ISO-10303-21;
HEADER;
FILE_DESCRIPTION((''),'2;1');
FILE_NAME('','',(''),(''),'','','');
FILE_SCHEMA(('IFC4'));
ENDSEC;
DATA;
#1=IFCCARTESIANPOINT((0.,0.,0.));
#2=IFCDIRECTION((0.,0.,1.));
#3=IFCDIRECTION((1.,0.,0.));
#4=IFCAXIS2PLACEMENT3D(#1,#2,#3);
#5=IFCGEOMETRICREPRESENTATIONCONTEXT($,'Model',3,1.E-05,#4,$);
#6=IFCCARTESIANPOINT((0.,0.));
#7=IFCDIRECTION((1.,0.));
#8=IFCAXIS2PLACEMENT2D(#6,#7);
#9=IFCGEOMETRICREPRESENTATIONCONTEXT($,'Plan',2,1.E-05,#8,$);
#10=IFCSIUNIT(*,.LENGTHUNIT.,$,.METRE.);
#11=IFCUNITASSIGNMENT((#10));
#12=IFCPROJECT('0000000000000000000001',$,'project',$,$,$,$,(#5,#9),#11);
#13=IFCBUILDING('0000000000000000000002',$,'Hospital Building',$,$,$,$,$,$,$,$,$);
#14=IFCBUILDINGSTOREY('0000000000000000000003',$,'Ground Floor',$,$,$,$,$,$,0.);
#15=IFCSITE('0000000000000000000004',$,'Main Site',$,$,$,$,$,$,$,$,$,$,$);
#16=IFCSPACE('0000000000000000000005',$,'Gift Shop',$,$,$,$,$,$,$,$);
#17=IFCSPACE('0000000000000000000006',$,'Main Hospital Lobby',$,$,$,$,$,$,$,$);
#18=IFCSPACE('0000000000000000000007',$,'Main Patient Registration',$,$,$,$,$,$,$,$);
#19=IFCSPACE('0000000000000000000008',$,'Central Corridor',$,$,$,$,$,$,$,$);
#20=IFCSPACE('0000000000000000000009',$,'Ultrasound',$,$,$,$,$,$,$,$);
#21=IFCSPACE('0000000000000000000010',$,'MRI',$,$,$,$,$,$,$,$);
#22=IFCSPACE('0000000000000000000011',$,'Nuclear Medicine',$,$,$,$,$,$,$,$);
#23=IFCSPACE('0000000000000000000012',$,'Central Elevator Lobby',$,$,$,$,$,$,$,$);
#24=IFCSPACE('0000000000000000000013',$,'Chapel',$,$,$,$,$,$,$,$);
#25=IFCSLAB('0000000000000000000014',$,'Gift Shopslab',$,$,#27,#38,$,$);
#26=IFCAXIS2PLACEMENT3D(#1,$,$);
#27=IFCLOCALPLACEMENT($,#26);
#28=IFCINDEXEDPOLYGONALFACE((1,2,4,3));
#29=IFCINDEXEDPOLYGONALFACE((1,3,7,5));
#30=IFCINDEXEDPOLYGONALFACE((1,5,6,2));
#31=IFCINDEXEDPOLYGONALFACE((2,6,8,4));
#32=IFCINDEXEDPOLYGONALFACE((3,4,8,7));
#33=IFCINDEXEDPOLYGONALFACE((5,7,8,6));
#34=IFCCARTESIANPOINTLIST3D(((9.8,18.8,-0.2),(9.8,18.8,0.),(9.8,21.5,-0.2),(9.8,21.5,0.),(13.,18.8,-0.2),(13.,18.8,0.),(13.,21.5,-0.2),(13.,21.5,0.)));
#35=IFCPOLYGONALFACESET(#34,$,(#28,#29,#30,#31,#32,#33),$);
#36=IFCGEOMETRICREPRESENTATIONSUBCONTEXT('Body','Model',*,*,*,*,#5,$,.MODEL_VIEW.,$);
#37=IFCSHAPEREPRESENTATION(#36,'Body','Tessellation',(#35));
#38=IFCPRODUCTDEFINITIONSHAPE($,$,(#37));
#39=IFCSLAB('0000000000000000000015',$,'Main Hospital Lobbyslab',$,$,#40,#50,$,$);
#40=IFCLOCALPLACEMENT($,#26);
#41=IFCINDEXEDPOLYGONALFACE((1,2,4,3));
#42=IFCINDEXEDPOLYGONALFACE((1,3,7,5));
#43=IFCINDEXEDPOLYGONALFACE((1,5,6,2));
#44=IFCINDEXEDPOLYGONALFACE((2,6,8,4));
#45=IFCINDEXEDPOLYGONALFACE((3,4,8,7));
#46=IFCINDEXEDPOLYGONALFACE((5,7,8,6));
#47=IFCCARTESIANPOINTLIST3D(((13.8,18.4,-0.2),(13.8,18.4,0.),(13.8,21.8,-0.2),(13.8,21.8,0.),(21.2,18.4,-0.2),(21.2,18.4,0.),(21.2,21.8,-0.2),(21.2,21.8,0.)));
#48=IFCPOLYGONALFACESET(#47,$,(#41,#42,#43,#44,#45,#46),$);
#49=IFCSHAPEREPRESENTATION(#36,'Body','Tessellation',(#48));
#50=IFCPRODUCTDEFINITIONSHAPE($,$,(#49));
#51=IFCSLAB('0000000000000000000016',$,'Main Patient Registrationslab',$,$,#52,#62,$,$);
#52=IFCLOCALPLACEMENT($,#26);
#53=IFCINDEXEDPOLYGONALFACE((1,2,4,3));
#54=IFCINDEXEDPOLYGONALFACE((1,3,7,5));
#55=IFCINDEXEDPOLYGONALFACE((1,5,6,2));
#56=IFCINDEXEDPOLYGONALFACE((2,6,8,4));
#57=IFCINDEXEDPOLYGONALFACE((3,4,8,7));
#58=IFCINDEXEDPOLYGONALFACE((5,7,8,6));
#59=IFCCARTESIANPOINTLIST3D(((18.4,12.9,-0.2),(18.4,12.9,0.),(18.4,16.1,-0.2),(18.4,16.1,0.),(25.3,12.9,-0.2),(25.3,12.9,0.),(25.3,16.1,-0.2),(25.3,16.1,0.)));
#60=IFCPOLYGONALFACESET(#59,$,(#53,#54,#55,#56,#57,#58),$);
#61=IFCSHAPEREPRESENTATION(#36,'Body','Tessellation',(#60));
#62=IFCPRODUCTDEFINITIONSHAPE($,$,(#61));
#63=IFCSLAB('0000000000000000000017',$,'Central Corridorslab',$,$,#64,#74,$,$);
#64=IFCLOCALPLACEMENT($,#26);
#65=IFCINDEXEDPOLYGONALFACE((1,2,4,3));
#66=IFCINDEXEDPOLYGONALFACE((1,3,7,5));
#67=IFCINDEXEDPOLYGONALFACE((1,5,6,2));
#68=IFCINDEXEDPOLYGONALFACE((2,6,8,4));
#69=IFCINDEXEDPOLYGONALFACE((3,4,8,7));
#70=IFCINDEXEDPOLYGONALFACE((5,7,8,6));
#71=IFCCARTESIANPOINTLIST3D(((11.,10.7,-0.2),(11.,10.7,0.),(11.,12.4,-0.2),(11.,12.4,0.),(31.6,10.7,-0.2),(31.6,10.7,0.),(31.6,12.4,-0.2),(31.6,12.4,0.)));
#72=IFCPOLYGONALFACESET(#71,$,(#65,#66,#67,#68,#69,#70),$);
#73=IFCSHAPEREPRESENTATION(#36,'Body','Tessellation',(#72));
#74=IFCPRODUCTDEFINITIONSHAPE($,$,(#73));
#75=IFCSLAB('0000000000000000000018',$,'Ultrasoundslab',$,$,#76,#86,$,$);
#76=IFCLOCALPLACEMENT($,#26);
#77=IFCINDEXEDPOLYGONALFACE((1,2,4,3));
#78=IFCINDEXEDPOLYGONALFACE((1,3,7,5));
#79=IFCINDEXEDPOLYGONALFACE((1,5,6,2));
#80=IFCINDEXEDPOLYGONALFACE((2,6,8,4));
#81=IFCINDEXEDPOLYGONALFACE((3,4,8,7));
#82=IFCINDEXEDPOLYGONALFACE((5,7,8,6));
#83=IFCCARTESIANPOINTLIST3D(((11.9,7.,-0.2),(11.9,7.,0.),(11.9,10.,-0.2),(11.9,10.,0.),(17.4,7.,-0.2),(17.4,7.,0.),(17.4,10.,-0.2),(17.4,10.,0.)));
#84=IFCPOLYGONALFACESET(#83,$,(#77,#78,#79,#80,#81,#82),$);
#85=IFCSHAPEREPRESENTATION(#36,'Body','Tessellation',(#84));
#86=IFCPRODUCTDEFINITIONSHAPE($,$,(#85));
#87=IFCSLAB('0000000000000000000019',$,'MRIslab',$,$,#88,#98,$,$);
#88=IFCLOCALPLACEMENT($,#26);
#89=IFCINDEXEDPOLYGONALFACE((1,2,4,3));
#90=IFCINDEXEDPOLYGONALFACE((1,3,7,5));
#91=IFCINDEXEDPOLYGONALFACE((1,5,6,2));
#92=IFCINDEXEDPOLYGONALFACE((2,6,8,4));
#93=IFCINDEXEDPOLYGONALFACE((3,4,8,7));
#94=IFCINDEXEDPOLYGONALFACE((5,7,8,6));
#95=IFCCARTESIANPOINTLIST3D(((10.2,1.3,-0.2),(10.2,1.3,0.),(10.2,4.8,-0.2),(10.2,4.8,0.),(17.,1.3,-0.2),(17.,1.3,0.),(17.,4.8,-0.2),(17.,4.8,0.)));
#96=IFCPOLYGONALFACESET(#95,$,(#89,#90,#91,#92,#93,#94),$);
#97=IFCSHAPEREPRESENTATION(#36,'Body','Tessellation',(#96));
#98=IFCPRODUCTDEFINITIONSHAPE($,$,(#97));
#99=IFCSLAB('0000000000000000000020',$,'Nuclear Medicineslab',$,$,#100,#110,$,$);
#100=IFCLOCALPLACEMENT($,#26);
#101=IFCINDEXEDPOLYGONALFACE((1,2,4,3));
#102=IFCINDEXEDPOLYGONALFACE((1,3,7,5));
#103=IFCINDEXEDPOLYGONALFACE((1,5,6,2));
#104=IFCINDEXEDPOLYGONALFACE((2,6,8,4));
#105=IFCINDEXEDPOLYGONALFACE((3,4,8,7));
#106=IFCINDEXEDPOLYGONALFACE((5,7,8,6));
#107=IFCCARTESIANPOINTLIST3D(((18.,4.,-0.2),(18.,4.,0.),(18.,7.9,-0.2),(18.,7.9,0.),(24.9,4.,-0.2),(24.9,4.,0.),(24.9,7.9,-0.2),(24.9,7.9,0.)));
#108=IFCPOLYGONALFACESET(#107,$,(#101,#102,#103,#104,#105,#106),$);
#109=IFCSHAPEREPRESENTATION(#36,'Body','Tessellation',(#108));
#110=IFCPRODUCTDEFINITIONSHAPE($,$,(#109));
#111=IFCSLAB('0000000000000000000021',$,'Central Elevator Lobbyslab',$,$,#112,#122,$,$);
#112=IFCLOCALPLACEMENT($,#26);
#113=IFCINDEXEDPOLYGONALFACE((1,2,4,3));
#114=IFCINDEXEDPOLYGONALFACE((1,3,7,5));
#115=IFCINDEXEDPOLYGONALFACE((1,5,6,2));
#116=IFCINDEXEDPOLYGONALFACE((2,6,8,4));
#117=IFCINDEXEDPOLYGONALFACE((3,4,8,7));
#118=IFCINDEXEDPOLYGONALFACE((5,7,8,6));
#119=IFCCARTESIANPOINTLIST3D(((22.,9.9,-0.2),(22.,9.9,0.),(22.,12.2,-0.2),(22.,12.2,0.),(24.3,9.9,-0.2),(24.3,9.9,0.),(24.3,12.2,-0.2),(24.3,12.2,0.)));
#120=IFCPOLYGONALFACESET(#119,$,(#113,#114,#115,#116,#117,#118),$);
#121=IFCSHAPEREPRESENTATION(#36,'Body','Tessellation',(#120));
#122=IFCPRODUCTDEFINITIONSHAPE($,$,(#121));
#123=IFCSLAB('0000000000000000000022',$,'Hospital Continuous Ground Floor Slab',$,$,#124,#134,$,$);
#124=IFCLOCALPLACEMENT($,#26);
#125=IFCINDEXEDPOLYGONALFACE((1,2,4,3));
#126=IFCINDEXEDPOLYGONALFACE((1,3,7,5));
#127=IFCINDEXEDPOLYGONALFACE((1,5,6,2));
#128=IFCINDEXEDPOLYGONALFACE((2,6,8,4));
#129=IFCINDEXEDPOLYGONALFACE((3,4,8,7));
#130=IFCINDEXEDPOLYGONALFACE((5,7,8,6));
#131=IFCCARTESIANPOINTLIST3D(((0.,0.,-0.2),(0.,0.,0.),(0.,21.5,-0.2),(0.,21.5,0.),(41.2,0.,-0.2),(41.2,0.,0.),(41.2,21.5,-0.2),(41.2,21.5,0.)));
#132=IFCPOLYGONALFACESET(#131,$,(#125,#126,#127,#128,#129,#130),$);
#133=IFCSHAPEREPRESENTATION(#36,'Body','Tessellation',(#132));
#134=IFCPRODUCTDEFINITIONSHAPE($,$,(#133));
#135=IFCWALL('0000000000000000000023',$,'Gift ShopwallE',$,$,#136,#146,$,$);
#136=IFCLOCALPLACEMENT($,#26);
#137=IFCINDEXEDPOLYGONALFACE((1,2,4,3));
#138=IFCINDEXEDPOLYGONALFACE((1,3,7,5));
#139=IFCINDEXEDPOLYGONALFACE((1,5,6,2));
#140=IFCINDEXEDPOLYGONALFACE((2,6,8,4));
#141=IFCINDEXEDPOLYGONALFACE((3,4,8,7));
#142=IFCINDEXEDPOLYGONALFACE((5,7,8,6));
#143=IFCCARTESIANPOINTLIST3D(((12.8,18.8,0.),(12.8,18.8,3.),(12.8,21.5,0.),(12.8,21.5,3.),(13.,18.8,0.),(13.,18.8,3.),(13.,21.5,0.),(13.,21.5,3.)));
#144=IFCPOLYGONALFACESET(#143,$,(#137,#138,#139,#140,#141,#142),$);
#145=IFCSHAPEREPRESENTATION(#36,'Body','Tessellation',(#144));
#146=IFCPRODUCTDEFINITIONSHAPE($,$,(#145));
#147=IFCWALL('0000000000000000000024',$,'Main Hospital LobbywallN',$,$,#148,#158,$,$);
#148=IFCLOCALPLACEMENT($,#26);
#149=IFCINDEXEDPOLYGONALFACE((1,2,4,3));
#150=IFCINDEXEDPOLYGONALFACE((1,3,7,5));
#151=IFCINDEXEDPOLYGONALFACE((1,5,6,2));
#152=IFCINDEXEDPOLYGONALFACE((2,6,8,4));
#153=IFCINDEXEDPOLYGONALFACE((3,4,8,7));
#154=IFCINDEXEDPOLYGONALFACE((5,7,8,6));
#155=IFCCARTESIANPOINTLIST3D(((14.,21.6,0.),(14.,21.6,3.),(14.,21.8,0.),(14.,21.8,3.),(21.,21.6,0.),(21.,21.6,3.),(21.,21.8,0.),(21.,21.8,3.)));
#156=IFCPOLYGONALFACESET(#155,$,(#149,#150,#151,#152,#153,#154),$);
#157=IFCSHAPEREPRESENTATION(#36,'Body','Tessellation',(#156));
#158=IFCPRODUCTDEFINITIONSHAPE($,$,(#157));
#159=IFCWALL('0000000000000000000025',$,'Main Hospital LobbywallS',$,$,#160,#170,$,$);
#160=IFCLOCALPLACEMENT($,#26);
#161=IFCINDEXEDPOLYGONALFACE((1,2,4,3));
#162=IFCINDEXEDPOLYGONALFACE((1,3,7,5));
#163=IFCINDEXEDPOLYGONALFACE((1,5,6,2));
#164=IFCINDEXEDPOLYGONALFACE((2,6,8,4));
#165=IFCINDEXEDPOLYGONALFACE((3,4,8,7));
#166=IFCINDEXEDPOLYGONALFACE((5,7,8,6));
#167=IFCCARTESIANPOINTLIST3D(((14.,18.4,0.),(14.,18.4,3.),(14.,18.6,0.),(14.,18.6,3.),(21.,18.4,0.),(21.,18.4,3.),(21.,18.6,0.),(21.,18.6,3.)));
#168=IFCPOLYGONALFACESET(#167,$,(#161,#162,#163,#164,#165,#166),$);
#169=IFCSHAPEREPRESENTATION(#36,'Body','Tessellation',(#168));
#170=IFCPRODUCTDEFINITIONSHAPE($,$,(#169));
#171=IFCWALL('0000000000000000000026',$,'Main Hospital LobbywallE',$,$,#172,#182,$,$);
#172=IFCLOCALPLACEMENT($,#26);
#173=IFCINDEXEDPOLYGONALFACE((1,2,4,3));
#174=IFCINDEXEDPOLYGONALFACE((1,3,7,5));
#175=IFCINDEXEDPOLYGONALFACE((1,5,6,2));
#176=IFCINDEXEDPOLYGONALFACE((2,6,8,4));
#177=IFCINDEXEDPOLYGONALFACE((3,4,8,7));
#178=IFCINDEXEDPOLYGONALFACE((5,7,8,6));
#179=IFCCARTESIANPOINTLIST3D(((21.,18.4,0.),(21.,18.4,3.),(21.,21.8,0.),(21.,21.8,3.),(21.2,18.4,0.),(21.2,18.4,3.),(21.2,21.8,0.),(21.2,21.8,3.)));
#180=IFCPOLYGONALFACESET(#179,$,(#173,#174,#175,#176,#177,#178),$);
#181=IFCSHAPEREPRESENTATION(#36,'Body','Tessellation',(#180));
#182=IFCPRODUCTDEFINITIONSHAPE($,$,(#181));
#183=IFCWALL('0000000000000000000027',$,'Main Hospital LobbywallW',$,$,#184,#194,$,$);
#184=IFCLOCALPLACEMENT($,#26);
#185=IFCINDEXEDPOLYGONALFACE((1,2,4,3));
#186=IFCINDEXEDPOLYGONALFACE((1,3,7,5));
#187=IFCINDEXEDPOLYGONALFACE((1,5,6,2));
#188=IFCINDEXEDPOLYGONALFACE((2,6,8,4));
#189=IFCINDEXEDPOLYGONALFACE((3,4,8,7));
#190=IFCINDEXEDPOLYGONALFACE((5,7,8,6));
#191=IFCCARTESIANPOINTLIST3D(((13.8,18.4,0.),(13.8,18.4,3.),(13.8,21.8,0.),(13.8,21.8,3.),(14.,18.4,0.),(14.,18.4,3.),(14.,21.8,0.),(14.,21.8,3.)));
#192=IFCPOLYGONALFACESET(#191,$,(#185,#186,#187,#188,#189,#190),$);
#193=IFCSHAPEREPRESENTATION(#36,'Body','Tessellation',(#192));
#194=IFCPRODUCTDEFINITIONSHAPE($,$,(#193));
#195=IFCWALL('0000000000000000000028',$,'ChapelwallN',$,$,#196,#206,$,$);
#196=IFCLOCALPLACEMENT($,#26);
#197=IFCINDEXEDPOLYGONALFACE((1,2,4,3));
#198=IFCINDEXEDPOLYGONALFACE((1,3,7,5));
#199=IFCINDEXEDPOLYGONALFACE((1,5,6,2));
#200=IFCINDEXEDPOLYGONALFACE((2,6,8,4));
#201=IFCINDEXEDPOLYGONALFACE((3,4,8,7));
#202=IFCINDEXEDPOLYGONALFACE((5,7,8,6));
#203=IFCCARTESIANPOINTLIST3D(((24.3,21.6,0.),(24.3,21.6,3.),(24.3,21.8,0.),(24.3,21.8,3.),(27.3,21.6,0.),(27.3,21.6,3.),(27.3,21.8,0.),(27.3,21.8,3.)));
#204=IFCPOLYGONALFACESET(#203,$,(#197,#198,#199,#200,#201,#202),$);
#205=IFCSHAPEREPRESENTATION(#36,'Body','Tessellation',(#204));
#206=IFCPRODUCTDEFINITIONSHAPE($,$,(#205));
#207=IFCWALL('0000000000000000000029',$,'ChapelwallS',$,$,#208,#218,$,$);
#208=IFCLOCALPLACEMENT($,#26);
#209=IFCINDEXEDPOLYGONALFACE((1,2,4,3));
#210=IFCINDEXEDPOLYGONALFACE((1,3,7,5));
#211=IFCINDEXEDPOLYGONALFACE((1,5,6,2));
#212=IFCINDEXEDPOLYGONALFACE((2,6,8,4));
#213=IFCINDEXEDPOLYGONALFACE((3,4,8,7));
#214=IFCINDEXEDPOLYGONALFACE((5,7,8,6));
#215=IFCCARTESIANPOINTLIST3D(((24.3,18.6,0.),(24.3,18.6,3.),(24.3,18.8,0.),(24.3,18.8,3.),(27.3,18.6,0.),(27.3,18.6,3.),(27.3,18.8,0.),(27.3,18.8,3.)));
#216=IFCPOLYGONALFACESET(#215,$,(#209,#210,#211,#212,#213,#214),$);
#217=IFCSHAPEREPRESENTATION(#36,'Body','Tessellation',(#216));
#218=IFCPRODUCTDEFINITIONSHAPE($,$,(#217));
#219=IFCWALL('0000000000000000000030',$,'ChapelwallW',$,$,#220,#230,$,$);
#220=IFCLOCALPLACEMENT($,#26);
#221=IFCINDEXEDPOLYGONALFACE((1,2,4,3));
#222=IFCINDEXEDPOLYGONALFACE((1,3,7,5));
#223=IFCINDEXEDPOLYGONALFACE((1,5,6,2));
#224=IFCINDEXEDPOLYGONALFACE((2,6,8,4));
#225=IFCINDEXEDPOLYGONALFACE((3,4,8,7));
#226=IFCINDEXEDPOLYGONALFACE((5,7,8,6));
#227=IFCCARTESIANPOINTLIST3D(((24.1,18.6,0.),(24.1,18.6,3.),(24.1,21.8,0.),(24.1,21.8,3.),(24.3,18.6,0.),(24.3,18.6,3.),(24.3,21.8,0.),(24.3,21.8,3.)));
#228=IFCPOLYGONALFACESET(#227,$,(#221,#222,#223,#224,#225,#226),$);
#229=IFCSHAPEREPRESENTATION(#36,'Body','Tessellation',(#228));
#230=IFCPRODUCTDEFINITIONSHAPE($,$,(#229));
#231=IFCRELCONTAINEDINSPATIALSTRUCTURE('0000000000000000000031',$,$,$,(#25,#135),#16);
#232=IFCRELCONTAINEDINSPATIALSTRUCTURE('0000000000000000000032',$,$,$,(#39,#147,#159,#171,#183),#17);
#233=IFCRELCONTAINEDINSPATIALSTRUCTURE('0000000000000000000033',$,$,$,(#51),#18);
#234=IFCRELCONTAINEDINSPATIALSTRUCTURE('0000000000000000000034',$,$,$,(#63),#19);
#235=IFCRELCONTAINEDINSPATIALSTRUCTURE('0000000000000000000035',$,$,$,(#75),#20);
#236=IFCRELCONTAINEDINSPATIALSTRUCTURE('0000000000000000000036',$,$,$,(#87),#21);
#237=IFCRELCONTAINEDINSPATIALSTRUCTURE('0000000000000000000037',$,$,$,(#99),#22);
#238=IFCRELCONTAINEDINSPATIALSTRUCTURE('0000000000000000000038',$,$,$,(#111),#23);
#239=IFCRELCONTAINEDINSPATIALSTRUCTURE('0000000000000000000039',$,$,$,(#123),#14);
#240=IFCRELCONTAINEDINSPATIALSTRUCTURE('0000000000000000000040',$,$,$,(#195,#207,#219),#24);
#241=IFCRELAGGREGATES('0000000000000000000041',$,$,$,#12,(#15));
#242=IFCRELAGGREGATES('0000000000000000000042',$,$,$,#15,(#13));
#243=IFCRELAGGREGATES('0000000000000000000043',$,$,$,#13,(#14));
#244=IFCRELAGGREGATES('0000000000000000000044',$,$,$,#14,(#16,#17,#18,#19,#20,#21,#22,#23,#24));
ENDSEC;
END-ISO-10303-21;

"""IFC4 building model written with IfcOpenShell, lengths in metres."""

from ifc_helpers import new_model, si_unit, frame, origin_with_axes, origin_2d_with_axis, place, context, subcontext, project, spatial, indexed_curve, rectangle, outline, extrude, element, save


model = new_model("IFC4")

# Units and contexts
model_context = context("Model", 3, precision=1e-05, world=origin_with_axes())
plan_context = context("Plan", 2, precision=1e-05, world=origin_2d_with_axis())
body_context = subcontext(model_context, "Body", "Model", "MODEL_VIEW")
ifc_project = project(units=[si_unit("LENGTHUNIT", "METRE")], contexts=[model_context, plan_context])

# Site, building, storey, space
site = spatial("IfcSite", under=ifc_project, Name="Main Site")
building = spatial("IfcBuilding", under=site, Name="Hospital Building")
storey = spatial("IfcBuildingStorey", under=building, Name="Ground Floor", Elevation=0.0)
space_1 = spatial("IfcSpace", under=storey, Name="Gift Shop")

# Slab
slab_1_placement = place(None, frame((11.4, 20.15, -0.2), z_axis=(0.0, 0.0, 1.0), x_axis=(1.0, 0.0, 0.0)))
element("IfcSlab", 1, at=slab_1_placement, inside=space_1, Name="Gift Shopslab", context=body_context, shape_type="SweptSolid", body=[
    extrude(rectangle(XDim=3.2, YDim=2.7), origin_with_axes(), (0.0, 0.0, 1.0), 0.2),
])

# Shared definitions
space_2 = spatial("IfcSpace", under=storey, Name="Main Hospital Lobby")

# Slab
slab_2_placement = place(None, frame((17.5, 20.1, -0.2), z_axis=(0.0, 0.0, 1.0), x_axis=(1.0, 0.0, 0.0)))
element("IfcSlab", 2, at=slab_2_placement, inside=space_2, Name="Main Hospital Lobbyslab", context=body_context, shape_type="SweptSolid", body=[
    extrude(rectangle(XDim=7.4, YDim=3.4), origin_with_axes(), (0.0, 0.0, 1.0), 0.2),
])

# Shared definitions
space_3 = spatial("IfcSpace", under=storey, Name="Main Patient Registration")

# Slab
slab_3_placement = place(None, frame((21.85, 14.5, -0.2), z_axis=(0.0, 0.0, 1.0), x_axis=(1.0, 0.0, 0.0)))
element("IfcSlab", 3, at=slab_3_placement, inside=space_3, Name="Main Patient Registrationslab", context=body_context, shape_type="SweptSolid", body=[
    extrude(rectangle(XDim=6.9, YDim=3.2), origin_with_axes(), (0.0, 0.0, 1.0), 0.2),
])

# Shared definitions
space_4 = spatial("IfcSpace", under=storey, Name="Central Corridor")

# Slab
slab_4_placement = place(None, frame((21.3, 11.55, -0.2), z_axis=(0.0, 0.0, 1.0), x_axis=(1.0, 0.0, 0.0)))
element("IfcSlab", 4, at=slab_4_placement, inside=space_4, Name="Central Corridorslab", context=body_context, shape_type="SweptSolid", body=[
    extrude(rectangle(XDim=20.6, YDim=1.7), origin_with_axes(), (0.0, 0.0, 1.0), 0.2),
])

# Shared definitions
space_5 = spatial("IfcSpace", under=storey, Name="Ultrasound")

# Slab
slab_5_placement = place(None, frame((14.65, 8.5, -0.2), z_axis=(0.0, 0.0, 1.0), x_axis=(1.0, 0.0, 0.0)))
element("IfcSlab", 5, at=slab_5_placement, inside=space_5, Name="Ultrasoundslab", context=body_context, shape_type="SweptSolid", body=[
    extrude(rectangle(XDim=5.5, YDim=3.0), origin_with_axes(), (0.0, 0.0, 1.0), 0.2),
])

# Shared definitions
space_6 = spatial("IfcSpace", under=storey, Name="MRI")

# Slab
slab_6_placement = place(None, frame((13.6, 3.05, -0.2), z_axis=(0.0, 0.0, 1.0), x_axis=(1.0, 0.0, 0.0)))
element("IfcSlab", 6, at=slab_6_placement, inside=space_6, Name="MRIslab", context=body_context, shape_type="SweptSolid", body=[
    extrude(rectangle(XDim=6.8, YDim=3.5), origin_with_axes(), (0.0, 0.0, 1.0), 0.2),
])

# Shared definitions
space_7 = spatial("IfcSpace", under=storey, Name="Nuclear Medicine")

# Slab
slab_7_placement = place(None, frame((21.45, 5.95, -0.2), z_axis=(0.0, 0.0, 1.0), x_axis=(1.0, 0.0, 0.0)))
element("IfcSlab", 7, at=slab_7_placement, inside=space_7, Name="Nuclear Medicineslab", context=body_context, shape_type="SweptSolid", body=[
    extrude(rectangle(XDim=6.9, YDim=3.9), origin_with_axes(), (0.0, 0.0, 1.0), 0.2),
])

# Shared definitions
space_8 = spatial("IfcSpace", under=storey, Name="Central Elevator Lobby")

# Slabs
slab_8_placement = place(None, frame((23.15, 11.05, -0.2), z_axis=(0.0, 0.0, 1.0), x_axis=(1.0, 0.0, 0.0)))
element("IfcSlab", 8, at=slab_8_placement, inside=space_8, Name="Central Elevator Lobbyslab", context=body_context, shape_type="SweptSolid", body=[
    extrude(rectangle(XDim=2.3, YDim=2.3), origin_with_axes(), (0.0, 0.0, 1.0), 0.2),
])
slab_9_placement = place(None, frame((20.6, 10.75, -0.2), z_axis=(0.0, 0.0, 1.0), x_axis=(1.0, 0.0, 0.0)))
element("IfcSlab", 9, at=slab_9_placement, inside=storey, Name="Hospital Continuous Ground Floor Slab", context=body_context, shape_type="SweptSolid", body=[
    extrude(rectangle(XDim=41.2, YDim=21.5), origin_with_axes(), (0.0, 0.0, 1.0), 0.2),
])

# Walls
wall_1_placement = place(None, frame((13.0, 18.8, 0.0), z_axis=(0.0, 0.0, 1.0), x_axis=(0.0, 1.0, 0.0)))
element("IfcWall", 10, at=wall_1_placement, inside=space_1, Name="Gift ShopwallE", context=body_context, shape_type="SweptSolid", body=[
    extrude(outline(indexed_curve([(0.0, 0.0), (0.0, 0.2), (2.7, 0.2), (2.7, 0.0), (0.0, 0.0)], self_intersect=False)), origin_with_axes(), (0.0, 0.0, 1.0), 3.0),
])
for number, where, z_axis, x_axis, name in (
    (11, (14.0, 21.6, 0.0), (0.0, 0.0, 1.0), (1.0, 0.0, 0.0), "Main Hospital LobbywallN"),
    (12, (14.0, 18.4, 0.0), (0.0, 0.0, 1.0), (1.0, 0.0, 0.0), "Main Hospital LobbywallS"),
):
    element("IfcWall", number, at=place(None, frame(where, z_axis=z_axis, x_axis=x_axis)), inside=space_2, Name=name, context=body_context, shape_type="SweptSolid", body=[
        extrude(outline(indexed_curve([(0.0, 0.0), (0.0, 0.2), (7.0, 0.2), (7.0, 0.0), (0.0, 0.0)], self_intersect=False)), origin_with_axes(), (0.0, 0.0, 1.0), 3.0),
    ])
for number, where, z_axis, x_axis, name in (
    (13, (21.2, 18.4, 0.0), (0.0, 0.0, 1.0), (0.0, 1.0, 0.0), "Main Hospital LobbywallE"),
    (14, (14.0, 18.4, 0.0), (0.0, 0.0, 1.0), (0.0, 1.0, 0.0), "Main Hospital LobbywallW"),
):
    element("IfcWall", number, at=place(None, frame(where, z_axis=z_axis, x_axis=x_axis)), inside=space_2, Name=name, context=body_context, shape_type="SweptSolid", body=[
        extrude(outline(indexed_curve([(0.0, 0.0), (0.0, 0.2), (3.4, 0.2), (3.4, 0.0), (0.0, 0.0)], self_intersect=False)), origin_with_axes(), (0.0, 0.0, 1.0), 3.0),
    ])

# Shared definitions
space_9 = spatial("IfcSpace", under=storey, Name="Chapel")

# Walls
for number, where, z_axis, x_axis, name in (
    (15, (24.3, 21.6, 0.0), (0.0, 0.0, 1.0), (1.0, 0.0, 0.0), "ChapelwallN"),
    (16, (24.3, 18.6, 0.0), (0.0, 0.0, 1.0), (1.0, 0.0, 0.0), "ChapelwallS"),
):
    element("IfcWall", number, at=place(None, frame(where, z_axis=z_axis, x_axis=x_axis)), inside=space_9, Name=name, context=body_context, shape_type="SweptSolid", body=[
        extrude(outline(indexed_curve([(0.0, 0.0), (0.0, 0.2), (3.0, 0.2), (3.0, 0.0), (0.0, 0.0)], self_intersect=False)), origin_with_axes(), (0.0, 0.0, 1.0), 3.0),
    ])
wall_2_placement = place(None, frame((24.3, 18.6, 0.0), z_axis=(0.0, 0.0, 1.0), x_axis=(0.0, 1.0, 0.0)))
element("IfcWall", 17, at=wall_2_placement, inside=space_9, Name="ChapelwallW", context=body_context, shape_type="SweptSolid", body=[
    extrude(outline(indexed_curve([(0.0, 0.0), (0.0, 0.2), (3.2, 0.2), (3.2, 0.0), (0.0, 0.0)], self_intersect=False)), origin_with_axes(), (0.0, 0.0, 1.0), 3.0),
])

save(model, "model.ifc")
